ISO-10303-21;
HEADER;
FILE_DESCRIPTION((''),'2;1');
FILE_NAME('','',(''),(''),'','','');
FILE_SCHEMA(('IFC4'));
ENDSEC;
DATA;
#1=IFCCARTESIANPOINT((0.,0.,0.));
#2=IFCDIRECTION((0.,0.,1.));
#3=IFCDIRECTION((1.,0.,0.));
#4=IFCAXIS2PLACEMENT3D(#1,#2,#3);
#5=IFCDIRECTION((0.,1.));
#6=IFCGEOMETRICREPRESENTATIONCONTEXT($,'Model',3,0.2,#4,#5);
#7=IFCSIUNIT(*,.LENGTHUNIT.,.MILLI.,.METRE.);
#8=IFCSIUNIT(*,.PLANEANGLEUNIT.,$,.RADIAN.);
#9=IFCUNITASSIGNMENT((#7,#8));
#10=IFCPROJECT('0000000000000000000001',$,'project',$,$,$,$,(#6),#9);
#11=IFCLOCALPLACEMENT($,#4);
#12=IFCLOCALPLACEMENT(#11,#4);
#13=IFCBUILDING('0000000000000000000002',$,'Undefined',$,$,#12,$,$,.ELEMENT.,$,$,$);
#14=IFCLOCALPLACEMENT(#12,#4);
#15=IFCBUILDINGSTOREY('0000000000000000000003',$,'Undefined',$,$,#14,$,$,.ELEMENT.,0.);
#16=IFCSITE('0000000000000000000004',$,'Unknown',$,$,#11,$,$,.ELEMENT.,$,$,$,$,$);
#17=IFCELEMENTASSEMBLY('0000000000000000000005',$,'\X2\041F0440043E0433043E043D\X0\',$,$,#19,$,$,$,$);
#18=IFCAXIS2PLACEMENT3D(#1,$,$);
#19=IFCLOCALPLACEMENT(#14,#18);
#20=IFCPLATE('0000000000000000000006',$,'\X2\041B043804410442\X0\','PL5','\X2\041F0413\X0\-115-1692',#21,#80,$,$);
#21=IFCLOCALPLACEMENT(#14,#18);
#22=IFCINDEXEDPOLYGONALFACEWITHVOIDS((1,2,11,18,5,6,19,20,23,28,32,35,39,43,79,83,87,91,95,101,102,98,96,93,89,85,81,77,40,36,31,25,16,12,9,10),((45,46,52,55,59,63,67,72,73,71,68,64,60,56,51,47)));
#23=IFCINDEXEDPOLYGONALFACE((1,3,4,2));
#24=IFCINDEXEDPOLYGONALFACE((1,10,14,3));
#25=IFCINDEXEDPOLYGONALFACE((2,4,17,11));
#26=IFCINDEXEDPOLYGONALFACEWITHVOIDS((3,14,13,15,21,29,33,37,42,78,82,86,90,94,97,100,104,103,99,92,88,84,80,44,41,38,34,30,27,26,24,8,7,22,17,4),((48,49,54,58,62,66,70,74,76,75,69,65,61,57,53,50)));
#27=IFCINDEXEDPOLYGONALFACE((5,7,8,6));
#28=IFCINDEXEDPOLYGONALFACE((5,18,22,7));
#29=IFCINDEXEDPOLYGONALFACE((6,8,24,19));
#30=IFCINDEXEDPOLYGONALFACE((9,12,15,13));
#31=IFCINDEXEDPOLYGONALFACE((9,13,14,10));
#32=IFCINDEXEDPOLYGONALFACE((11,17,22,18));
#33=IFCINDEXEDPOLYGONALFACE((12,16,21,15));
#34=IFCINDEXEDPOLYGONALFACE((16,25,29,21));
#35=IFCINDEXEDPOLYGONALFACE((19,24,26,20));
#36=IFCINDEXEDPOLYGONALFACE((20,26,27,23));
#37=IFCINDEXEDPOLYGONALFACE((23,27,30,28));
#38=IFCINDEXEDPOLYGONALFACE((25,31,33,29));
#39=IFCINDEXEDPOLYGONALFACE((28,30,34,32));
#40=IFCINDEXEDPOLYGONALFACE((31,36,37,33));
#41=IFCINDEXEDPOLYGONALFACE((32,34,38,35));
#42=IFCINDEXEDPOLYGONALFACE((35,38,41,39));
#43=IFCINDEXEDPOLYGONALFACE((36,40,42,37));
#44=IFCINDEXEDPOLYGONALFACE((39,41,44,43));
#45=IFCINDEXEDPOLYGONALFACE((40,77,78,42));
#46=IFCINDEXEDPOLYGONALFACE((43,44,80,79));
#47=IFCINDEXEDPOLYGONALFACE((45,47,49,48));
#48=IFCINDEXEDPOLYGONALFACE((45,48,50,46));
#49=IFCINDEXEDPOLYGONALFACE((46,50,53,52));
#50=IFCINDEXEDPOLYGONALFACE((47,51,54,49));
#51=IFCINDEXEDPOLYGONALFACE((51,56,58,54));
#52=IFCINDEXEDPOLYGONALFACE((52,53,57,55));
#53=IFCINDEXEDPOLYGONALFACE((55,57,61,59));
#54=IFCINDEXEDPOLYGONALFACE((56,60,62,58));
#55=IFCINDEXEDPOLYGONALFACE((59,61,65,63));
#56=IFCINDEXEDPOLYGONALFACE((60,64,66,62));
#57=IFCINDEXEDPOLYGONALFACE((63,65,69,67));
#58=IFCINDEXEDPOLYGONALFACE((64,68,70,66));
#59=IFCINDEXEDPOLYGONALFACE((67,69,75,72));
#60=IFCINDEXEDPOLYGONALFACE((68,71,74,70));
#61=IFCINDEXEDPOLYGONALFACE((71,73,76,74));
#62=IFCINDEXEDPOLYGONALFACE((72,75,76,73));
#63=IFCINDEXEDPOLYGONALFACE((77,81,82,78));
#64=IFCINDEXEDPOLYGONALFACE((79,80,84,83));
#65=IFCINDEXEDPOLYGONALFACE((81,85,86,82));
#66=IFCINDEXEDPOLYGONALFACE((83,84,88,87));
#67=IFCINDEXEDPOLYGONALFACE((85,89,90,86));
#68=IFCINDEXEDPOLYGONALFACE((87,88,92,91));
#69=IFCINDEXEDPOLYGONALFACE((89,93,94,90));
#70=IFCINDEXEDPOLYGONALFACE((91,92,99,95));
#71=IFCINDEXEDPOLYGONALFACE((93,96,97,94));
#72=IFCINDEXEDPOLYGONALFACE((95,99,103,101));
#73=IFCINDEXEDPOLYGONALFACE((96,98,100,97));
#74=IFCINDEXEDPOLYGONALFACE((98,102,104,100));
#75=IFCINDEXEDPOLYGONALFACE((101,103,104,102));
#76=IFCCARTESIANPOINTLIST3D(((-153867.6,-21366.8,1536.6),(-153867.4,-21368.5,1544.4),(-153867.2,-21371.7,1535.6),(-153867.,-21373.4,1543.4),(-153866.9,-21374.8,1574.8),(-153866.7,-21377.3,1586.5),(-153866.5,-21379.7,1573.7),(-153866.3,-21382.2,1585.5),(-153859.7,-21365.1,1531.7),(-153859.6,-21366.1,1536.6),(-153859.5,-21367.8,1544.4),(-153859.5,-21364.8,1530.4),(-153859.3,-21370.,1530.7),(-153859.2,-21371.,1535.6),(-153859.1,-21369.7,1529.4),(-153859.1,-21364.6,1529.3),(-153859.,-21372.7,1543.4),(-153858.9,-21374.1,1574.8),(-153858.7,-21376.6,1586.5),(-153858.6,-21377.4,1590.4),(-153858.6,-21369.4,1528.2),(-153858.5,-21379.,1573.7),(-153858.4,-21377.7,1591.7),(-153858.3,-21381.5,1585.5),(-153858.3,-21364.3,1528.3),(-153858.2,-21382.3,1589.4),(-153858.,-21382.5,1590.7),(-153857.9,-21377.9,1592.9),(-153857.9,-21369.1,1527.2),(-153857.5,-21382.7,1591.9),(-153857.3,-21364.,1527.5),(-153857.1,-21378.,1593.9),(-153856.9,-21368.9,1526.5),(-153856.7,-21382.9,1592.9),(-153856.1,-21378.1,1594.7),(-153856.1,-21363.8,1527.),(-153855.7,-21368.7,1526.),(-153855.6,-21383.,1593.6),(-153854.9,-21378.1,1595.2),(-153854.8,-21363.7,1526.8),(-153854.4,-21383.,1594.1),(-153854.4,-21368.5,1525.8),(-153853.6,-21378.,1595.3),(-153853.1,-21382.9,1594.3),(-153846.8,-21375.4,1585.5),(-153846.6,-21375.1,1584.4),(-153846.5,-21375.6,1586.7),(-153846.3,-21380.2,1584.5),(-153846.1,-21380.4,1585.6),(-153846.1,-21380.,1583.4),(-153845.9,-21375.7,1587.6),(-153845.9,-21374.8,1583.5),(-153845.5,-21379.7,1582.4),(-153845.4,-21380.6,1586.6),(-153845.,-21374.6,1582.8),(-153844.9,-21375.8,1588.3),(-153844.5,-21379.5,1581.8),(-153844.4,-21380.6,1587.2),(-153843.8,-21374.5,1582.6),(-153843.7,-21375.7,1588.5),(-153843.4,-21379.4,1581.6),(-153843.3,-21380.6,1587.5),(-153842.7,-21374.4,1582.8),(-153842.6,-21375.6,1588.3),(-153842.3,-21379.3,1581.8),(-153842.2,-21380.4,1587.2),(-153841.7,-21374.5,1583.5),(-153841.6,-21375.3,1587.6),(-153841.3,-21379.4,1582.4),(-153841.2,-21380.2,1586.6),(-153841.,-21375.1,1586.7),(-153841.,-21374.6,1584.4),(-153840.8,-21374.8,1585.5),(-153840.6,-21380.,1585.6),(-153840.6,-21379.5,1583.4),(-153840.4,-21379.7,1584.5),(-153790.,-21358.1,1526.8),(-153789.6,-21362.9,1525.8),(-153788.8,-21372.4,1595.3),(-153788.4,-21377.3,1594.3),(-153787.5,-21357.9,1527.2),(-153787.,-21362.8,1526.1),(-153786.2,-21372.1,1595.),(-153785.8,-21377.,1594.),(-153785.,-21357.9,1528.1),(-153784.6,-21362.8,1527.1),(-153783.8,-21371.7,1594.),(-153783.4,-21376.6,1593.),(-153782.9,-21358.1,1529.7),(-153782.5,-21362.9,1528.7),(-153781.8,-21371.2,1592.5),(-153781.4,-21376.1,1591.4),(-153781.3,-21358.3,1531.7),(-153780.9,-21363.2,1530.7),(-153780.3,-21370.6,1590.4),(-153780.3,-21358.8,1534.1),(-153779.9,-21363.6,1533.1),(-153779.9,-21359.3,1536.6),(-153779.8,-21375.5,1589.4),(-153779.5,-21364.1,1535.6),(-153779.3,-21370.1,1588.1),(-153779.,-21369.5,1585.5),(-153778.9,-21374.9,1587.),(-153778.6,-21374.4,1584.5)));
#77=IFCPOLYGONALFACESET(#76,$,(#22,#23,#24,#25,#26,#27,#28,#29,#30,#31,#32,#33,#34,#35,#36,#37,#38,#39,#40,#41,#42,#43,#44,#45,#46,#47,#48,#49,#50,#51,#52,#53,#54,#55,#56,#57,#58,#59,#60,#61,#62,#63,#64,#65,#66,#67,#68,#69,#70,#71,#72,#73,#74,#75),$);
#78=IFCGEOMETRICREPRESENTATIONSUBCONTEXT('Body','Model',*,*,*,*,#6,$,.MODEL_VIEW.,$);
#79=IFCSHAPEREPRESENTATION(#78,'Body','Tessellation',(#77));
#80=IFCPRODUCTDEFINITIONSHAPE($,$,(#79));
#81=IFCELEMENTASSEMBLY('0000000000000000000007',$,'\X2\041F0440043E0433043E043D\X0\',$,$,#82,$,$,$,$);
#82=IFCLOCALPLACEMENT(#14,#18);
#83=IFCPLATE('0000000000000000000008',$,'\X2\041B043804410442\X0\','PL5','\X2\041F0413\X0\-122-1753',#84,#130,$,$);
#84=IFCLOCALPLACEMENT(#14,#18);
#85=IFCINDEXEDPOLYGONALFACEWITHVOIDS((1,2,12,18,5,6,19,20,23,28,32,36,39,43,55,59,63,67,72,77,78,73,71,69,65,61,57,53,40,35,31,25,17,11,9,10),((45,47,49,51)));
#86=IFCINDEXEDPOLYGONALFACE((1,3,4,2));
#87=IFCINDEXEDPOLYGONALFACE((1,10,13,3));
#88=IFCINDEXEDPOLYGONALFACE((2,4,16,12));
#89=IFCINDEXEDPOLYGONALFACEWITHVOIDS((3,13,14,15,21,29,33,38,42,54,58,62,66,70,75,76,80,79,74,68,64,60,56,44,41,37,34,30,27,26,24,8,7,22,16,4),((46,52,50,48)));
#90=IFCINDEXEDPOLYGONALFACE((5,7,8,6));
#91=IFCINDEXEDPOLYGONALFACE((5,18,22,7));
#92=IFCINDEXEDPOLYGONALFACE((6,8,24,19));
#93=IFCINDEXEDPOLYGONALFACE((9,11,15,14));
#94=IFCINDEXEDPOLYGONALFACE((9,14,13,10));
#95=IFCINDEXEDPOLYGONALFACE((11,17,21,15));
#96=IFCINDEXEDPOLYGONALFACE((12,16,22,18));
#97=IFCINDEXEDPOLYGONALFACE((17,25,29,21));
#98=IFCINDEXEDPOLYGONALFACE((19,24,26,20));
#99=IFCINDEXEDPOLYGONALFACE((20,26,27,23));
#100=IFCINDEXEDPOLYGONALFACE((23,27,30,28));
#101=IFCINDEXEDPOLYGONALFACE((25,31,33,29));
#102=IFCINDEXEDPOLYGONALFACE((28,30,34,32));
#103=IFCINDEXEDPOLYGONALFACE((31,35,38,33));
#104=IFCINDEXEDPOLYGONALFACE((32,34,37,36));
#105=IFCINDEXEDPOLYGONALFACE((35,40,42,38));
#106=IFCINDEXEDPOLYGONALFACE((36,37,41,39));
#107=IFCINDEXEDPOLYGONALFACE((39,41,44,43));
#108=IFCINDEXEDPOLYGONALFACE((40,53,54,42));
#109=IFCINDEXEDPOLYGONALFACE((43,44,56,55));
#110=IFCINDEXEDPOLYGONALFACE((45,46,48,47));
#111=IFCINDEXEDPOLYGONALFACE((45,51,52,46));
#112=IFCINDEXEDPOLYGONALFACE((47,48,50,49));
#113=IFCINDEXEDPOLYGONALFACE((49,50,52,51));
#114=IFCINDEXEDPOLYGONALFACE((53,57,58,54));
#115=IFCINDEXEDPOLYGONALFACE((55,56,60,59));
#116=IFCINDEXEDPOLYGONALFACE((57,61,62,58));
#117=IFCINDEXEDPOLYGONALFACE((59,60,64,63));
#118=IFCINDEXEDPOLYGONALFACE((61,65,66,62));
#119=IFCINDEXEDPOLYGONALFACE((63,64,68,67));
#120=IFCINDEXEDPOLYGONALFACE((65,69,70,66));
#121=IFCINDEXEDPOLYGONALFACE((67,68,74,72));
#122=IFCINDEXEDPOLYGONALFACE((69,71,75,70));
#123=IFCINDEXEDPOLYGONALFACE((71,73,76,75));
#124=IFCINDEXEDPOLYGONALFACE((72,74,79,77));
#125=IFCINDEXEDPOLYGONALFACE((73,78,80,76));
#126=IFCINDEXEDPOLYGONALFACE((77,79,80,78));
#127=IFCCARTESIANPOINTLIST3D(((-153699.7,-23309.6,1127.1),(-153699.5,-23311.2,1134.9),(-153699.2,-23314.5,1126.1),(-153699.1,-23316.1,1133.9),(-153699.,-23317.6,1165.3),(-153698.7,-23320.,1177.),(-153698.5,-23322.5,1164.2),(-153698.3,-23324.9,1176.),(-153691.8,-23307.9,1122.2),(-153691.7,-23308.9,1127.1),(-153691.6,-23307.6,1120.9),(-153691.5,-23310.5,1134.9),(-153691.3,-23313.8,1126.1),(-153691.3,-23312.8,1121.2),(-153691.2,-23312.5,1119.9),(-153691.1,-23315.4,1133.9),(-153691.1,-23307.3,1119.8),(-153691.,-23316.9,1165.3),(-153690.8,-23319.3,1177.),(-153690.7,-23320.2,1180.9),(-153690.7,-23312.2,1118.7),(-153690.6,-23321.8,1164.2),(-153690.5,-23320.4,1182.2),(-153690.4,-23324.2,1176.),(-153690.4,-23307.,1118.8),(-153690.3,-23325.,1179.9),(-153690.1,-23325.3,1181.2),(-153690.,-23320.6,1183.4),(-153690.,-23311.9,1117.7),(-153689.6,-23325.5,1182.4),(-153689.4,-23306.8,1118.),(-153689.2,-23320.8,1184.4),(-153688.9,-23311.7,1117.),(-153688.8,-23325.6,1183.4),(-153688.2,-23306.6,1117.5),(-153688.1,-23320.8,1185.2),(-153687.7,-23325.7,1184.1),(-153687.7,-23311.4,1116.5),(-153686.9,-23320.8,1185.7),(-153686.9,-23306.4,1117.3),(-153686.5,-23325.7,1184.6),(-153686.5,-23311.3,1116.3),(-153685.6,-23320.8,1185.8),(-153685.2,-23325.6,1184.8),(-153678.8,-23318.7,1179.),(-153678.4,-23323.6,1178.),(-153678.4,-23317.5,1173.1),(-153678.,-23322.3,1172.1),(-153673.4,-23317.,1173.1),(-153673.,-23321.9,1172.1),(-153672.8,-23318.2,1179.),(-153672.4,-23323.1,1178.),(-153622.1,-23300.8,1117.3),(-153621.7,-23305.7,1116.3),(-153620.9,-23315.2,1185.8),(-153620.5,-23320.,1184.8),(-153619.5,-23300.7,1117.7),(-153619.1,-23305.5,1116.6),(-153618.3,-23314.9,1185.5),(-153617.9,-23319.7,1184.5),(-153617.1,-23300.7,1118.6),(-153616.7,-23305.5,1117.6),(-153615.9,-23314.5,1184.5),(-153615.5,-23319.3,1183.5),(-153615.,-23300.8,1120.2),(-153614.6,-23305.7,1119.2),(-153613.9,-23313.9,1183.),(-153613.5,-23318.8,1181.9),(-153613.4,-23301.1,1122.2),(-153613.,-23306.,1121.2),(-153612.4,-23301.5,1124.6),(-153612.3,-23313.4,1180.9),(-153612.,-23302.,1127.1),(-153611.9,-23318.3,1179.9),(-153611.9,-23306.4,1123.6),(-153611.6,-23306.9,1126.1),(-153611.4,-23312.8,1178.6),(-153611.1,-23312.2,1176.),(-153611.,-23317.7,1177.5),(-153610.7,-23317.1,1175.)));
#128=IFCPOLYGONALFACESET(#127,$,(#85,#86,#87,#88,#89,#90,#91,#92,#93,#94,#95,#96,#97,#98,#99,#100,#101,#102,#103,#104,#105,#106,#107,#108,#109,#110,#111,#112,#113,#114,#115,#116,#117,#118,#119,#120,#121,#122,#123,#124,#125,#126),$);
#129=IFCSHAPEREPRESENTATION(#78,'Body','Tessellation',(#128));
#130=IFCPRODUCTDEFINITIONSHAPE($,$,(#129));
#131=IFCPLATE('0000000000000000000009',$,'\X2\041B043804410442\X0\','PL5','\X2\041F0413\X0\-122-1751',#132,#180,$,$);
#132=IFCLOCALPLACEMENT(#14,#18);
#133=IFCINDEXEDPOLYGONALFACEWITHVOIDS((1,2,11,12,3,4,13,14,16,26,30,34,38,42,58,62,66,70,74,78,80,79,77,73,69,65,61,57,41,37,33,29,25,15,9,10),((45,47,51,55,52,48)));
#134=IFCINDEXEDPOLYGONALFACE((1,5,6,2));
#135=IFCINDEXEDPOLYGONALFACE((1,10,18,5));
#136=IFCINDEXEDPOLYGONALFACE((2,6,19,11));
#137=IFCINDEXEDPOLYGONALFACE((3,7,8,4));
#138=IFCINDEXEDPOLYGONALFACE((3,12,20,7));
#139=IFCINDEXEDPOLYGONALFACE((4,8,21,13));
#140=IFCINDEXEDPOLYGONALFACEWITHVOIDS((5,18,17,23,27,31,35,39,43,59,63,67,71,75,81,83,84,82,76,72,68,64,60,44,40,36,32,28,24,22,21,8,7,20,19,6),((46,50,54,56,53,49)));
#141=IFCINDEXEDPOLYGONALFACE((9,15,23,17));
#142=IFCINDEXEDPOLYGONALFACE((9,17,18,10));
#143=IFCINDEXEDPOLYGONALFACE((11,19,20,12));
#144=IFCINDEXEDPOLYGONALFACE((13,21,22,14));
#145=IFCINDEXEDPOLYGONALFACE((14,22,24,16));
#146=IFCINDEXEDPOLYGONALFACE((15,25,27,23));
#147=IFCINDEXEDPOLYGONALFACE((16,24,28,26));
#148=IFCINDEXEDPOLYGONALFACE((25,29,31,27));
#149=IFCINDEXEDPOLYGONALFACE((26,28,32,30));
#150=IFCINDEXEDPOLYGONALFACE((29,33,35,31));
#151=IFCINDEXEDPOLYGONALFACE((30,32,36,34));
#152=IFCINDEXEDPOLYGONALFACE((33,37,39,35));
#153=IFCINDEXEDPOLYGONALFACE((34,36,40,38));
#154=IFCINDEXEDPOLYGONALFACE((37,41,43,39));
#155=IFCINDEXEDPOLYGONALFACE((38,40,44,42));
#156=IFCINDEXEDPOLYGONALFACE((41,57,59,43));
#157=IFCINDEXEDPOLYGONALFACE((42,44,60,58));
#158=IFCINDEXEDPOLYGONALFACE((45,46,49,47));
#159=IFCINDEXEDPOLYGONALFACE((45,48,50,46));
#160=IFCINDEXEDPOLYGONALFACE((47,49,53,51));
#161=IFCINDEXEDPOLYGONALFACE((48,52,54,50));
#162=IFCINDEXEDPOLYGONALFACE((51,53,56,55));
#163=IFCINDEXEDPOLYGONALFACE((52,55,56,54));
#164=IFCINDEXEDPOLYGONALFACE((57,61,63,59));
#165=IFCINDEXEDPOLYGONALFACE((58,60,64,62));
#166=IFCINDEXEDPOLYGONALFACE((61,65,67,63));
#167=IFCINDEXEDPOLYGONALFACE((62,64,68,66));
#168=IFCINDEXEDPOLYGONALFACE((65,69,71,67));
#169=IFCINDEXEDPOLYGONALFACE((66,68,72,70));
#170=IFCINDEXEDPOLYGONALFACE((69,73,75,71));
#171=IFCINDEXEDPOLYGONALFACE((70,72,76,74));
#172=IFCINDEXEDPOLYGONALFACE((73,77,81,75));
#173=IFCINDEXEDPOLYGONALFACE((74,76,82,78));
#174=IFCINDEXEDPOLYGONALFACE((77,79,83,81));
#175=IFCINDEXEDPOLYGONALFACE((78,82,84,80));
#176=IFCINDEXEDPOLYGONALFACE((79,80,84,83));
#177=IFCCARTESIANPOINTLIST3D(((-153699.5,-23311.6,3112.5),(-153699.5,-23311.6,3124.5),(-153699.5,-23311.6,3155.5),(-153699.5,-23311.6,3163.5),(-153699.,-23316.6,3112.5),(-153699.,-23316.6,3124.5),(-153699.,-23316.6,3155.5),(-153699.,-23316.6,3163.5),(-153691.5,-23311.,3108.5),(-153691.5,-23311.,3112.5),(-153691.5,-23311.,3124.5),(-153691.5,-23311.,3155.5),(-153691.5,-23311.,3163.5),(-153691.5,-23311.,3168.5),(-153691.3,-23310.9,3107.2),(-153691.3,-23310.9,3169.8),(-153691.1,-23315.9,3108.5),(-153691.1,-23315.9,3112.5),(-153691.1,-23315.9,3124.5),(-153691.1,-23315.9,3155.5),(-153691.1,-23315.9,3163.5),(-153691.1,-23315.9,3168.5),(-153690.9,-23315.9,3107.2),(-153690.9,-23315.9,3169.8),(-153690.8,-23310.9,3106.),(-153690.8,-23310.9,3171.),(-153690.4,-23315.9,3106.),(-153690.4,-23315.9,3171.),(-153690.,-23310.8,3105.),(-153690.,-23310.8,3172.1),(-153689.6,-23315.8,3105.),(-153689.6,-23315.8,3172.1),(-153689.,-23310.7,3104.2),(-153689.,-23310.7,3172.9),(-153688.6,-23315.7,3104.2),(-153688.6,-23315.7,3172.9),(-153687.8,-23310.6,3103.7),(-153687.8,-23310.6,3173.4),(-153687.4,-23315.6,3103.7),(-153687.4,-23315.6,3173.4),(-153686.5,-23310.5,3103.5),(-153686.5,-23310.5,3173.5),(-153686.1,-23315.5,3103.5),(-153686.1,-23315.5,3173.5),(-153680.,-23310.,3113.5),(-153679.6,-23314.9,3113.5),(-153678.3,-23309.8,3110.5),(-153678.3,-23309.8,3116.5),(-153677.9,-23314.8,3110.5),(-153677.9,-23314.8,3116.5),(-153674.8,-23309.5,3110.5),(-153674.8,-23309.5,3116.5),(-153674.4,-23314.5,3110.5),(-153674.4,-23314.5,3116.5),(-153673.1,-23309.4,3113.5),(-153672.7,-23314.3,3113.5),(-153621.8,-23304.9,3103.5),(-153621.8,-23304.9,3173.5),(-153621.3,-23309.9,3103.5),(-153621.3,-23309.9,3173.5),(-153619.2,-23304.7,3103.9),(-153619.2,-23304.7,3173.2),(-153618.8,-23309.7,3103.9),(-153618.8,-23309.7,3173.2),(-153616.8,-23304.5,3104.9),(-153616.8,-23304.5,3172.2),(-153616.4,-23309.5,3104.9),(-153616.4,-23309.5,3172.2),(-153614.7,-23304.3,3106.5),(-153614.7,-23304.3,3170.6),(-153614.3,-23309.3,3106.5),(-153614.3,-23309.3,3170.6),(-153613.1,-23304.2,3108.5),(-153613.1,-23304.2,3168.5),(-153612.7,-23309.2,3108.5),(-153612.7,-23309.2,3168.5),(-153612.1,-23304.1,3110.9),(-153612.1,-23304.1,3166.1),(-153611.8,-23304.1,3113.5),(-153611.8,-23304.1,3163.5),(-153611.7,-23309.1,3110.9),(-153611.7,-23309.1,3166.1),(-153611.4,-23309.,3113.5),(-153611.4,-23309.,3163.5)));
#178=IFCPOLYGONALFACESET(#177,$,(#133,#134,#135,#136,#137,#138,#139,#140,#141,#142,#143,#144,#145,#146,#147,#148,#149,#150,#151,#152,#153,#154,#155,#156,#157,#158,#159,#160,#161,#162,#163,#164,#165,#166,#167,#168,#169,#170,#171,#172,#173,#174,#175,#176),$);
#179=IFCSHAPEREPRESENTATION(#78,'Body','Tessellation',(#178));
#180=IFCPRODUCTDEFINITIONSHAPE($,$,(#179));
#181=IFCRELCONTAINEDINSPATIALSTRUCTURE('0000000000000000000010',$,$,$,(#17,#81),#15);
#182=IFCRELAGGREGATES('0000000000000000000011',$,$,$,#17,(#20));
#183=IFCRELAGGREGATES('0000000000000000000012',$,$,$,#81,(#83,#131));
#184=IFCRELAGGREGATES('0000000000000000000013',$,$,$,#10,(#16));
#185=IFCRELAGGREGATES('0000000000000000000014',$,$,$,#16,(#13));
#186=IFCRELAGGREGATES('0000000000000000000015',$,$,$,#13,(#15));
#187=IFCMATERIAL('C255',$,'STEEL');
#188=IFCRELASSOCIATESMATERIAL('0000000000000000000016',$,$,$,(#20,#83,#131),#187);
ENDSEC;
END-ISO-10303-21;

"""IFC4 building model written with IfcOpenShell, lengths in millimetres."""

from ifc_helpers import new_model, si_unit, direction, frame, origin_with_axes, place, context, subcontext, project, spatial, line, arc, indexed_curve, outline, extrude, material, element, aggregate, save


model = new_model("IFC4")

# Units and contexts
model_context = context("Model", 3, precision=0.2, world=origin_with_axes(), true_north=direction((0.0, 1.0)))
body_context = subcontext(model_context, "Body", "Model", "MODEL_VIEW")
ifc_project = project(units=[si_unit("LENGTHUNIT", "METRE", prefix="MILLI"), si_unit("PLANEANGLEUNIT", "RADIAN")], contexts=[model_context])

# Site, building, storey
site_placement = place(None, origin_with_axes())
site = spatial("IfcSite", under=ifc_project, at=site_placement, Name="Unknown", CompositionType="ELEMENT")
building_placement = place(site_placement, origin_with_axes())
building = spatial("IfcBuilding", under=site, at=building_placement, Name="Undefined", CompositionType="ELEMENT")
storey_placement = place(building_placement, origin_with_axes())
storey = spatial("IfcBuildingStorey", under=building, at=storey_placement, Name="Undefined", CompositionType="ELEMENT", Elevation=0.0)

# Element assemblies, plates, voiding features
ifc_material_1 = material(Name="C255", Category="STEEL")
assembly_1_placement = place(storey_placement, frame((-153899.1, -21374.1, 1131.2), z_axis=(0.086114, -0.996285, 0.0), x_axis=(0.0, 0.0, 1.0)))
assembly_1 = element("IfcElementAssembly", 1, at=assembly_1_placement, inside=storey, Name="Прогон")
plate_1_placement = place(assembly_1_placement, frame((395.1, -120.0, -4.2), z_axis=(-0.205517, -0.000052, 0.978653), x_axis=(0.978653, 0.00003, 0.205517)))
plate_1 = element("IfcPlate", 2, at=plate_1_placement, material=ifc_material_1, Name="Лист", Description="PL5", ObjectType="ПГ-115-1692", context=body_context, shape_type="SolidModel", body=[
    extrude(outline(indexed_curve([(0.0, 10.0), (2.9, 2.9), (10.0, 0.0), (60.0, 0.0), (67.1, 2.9), (70.0, 10.0), (70.0, 75.0), (68.5, 78.5), (65.0, 80.0), (61.0, 80.0), (61.0, 88.0), (49.0, 88.0), (49.0, 80.0), (18.0, 80.0), (18.0, 88.0), (10.0, 88.0), (10.0, 80.0), (5.0, 80.0), (1.5, 78.5), (0.0, 75.0)], segments=[arc(1, 2, 3), line(3, 4), arc(4, 5, 6), line(6, 7), arc(7, 8, 9), line(9, 10, 11, 12, 13, 14, 15, 16, 17, 18), arc(18, 19, 20), line(20, 1)])), frame((0.0, 0.0, 2.5), z_axis=(0.0, 0.0, 1.0), x_axis=(1.0, 0.0, 0.0)), (0.0, 0.0, -1.0), 5.0),
])
voiding_feature_1_placement = place(plate_1_placement, frame((60.0, 65.0, 6.0), z_axis=(-0.000054, -1.0, 0.000034), x_axis=(0.0, -0.000034, -1.0)))
element("IfcVoidingFeature", 3, at=voiding_feature_1_placement, cuts=plate_1, Name="Балка", ObjectType="(?)", PredefinedType="HOLE", context=body_context, shape_type="SolidModel", body=[
    extrude(outline(indexed_curve([(3.0, 0.0), (2.8, 1.1), (2.1, 2.1), (1.1, 2.8), (0.0, 3.0), (-1.1, 2.8), (-2.1, 2.1), (-2.8, 1.1), (-3.0, 0.0), (-2.8, -1.1), (-2.1, -2.1), (-1.1, -2.8), (0.0, -3.0), (1.1, -2.8), (2.1, -2.1), (2.8, -1.1)], segments=[line(1, 2, 3, 4, 5, 6, 7, 8, 9, 10, 11, 12, 13, 14, 15, 16, 1)])), frame((0.0, 0.0, 0.0), z_axis=(-1.0, 0.0, 0.0), x_axis=(0.0, 0.0, 1.0)), (0.0, 0.0, -1.0), 12.0),
])
assembly_2_placement = place(storey_placement, frame((-153731.1, -23316.9, 683.6), z_axis=(0.086114, -0.996285, 0.0), x_axis=(0.0, 0.0, 1.0)))
assembly_2 = element("IfcElementAssembly", 4, at=assembly_2_placement, inside=storey, Name="Прогон")
plate_2_placement = place(assembly_2_placement, frame((433.2, -120.0, -4.2), z_axis=(-0.205517, -0.000052, 0.978653), x_axis=(0.978653, 0.00003, 0.205517)))
plate_2 = element("IfcPlate", 5, at=plate_2_placement, material=ifc_material_1, Name="Лист", Description="PL5", ObjectType="ПГ-122-1753", context=body_context, shape_type="SolidModel", body=[
    extrude(outline(indexed_curve([(0.0, 10.0), (2.9, 2.9), (10.0, 0.0), (60.0, 0.0), (67.1, 2.9), (70.0, 10.0), (70.0, 75.0), (68.5, 78.5), (65.0, 80.0), (61.0, 80.0), (61.0, 88.0), (49.0, 88.0), (49.0, 80.0), (18.0, 80.0), (18.0, 88.0), (10.0, 88.0), (10.0, 80.0), (5.0, 80.0), (1.5, 78.5), (0.0, 75.0)], segments=[arc(1, 2, 3), line(3, 4), arc(4, 5, 6), line(6, 7), arc(7, 8, 9), line(9, 10, 11, 12, 13, 14, 15, 16, 17, 18), arc(18, 19, 20), line(20, 1)])), frame((0.0, 0.0, 2.5), z_axis=(0.0, 0.0, 1.0), x_axis=(1.0, 0.0, 0.0)), (0.0, 0.0, -1.0), 5.0),
])
voiding_feature_2_placement = place(plate_2_placement, frame((60.0, 65.0, 6.0), z_axis=(-0.000054, -1.0, 0.000034), x_axis=(0.0, -0.000034, -1.0)))
element("IfcVoidingFeature", 6, at=voiding_feature_2_placement, cuts=plate_2, Name="Балка", ObjectType="(?)", PredefinedType="HOLE", context=body_context, shape_type="SolidModel", body=[
    extrude(outline(indexed_curve([(2.5, -3.0), (3.0, 3.0), (-3.0, 3.0), (-2.5, -3.0)], segments=[line(1, 2, 3, 4, 1)])), frame((0.0, 0.0, 0.0), z_axis=(-1.0, 0.0, 0.0), x_axis=(0.0, 0.0, 1.0)), (0.0, 0.0, -1.0), 12.0),
])
plate_3_placement = place(assembly_2_placement, frame((2489.9, -120.0, 0.0), z_axis=(0.0, -0.000057, -1.0), x_axis=(-1.0, 0.000024, 0.0)))
plate_3 = element("IfcPlate", 7, at=plate_3_placement, material=ifc_material_1, Name="Лист", Description="PL5", ObjectType="ПГ-122-1751", context=body_context, shape_type="SolidModel", body=[
    extrude(outline(indexed_curve([(0.0, 10.0), (2.9, 2.9), (10.0, 0.0), (60.0, 0.0), (67.1, 2.9), (70.0, 10.0), (70.0, 75.0), (68.5, 78.5), (65.0, 80.0), (61.0, 80.0), (61.0, 88.0), (49.0, 88.0), (49.0, 80.0), (18.0, 80.0), (18.0, 88.0), (10.0, 88.0), (10.0, 80.0), (5.0, 80.0), (1.5, 78.5), (0.0, 75.0)], segments=[arc(1, 2, 3), line(3, 4), arc(4, 5, 6), line(6, 7), arc(7, 8, 9), line(9, 10, 11, 12, 13, 14, 15, 16, 17, 18), arc(18, 19, 20), line(20, 1)])), frame((0.0, 0.0, 2.5), z_axis=(0.0, 0.0, 1.0), x_axis=(1.0, 0.0, 0.0)), (0.0, 0.0, -1.0), 5.0),
])
voiding_feature_3_placement = place(plate_3_placement, frame((60.0, 65.0, 6.0), z_axis=(-0.000054, -1.0, 0.000034), x_axis=(0.0, -0.000034, -1.0)))
element("IfcVoidingFeature", 8, at=voiding_feature_3_placement, cuts=plate_3, Name="Балка", ObjectType="(?)", PredefinedType="HOLE", context=body_context, shape_type="SolidModel", body=[
    extrude(outline(indexed_curve([(1.7, -3.0), (3.5, 0.0), (1.7, 3.0), (-1.7, 3.0), (-3.5, 0.0), (-1.7, -3.0)], segments=[line(1, 2, 3, 4, 5, 6, 1)])), frame((0.0, 0.0, 0.0), z_axis=(-1.0, 0.0, 0.0), x_axis=(0.0, 0.0, 1.0)), (0.0, 0.0, -1.0), 12.0),
])

aggregate(assembly_1, [plate_1])
aggregate(assembly_2, [plate_2, plate_3])

save(model, "model.ifc")
